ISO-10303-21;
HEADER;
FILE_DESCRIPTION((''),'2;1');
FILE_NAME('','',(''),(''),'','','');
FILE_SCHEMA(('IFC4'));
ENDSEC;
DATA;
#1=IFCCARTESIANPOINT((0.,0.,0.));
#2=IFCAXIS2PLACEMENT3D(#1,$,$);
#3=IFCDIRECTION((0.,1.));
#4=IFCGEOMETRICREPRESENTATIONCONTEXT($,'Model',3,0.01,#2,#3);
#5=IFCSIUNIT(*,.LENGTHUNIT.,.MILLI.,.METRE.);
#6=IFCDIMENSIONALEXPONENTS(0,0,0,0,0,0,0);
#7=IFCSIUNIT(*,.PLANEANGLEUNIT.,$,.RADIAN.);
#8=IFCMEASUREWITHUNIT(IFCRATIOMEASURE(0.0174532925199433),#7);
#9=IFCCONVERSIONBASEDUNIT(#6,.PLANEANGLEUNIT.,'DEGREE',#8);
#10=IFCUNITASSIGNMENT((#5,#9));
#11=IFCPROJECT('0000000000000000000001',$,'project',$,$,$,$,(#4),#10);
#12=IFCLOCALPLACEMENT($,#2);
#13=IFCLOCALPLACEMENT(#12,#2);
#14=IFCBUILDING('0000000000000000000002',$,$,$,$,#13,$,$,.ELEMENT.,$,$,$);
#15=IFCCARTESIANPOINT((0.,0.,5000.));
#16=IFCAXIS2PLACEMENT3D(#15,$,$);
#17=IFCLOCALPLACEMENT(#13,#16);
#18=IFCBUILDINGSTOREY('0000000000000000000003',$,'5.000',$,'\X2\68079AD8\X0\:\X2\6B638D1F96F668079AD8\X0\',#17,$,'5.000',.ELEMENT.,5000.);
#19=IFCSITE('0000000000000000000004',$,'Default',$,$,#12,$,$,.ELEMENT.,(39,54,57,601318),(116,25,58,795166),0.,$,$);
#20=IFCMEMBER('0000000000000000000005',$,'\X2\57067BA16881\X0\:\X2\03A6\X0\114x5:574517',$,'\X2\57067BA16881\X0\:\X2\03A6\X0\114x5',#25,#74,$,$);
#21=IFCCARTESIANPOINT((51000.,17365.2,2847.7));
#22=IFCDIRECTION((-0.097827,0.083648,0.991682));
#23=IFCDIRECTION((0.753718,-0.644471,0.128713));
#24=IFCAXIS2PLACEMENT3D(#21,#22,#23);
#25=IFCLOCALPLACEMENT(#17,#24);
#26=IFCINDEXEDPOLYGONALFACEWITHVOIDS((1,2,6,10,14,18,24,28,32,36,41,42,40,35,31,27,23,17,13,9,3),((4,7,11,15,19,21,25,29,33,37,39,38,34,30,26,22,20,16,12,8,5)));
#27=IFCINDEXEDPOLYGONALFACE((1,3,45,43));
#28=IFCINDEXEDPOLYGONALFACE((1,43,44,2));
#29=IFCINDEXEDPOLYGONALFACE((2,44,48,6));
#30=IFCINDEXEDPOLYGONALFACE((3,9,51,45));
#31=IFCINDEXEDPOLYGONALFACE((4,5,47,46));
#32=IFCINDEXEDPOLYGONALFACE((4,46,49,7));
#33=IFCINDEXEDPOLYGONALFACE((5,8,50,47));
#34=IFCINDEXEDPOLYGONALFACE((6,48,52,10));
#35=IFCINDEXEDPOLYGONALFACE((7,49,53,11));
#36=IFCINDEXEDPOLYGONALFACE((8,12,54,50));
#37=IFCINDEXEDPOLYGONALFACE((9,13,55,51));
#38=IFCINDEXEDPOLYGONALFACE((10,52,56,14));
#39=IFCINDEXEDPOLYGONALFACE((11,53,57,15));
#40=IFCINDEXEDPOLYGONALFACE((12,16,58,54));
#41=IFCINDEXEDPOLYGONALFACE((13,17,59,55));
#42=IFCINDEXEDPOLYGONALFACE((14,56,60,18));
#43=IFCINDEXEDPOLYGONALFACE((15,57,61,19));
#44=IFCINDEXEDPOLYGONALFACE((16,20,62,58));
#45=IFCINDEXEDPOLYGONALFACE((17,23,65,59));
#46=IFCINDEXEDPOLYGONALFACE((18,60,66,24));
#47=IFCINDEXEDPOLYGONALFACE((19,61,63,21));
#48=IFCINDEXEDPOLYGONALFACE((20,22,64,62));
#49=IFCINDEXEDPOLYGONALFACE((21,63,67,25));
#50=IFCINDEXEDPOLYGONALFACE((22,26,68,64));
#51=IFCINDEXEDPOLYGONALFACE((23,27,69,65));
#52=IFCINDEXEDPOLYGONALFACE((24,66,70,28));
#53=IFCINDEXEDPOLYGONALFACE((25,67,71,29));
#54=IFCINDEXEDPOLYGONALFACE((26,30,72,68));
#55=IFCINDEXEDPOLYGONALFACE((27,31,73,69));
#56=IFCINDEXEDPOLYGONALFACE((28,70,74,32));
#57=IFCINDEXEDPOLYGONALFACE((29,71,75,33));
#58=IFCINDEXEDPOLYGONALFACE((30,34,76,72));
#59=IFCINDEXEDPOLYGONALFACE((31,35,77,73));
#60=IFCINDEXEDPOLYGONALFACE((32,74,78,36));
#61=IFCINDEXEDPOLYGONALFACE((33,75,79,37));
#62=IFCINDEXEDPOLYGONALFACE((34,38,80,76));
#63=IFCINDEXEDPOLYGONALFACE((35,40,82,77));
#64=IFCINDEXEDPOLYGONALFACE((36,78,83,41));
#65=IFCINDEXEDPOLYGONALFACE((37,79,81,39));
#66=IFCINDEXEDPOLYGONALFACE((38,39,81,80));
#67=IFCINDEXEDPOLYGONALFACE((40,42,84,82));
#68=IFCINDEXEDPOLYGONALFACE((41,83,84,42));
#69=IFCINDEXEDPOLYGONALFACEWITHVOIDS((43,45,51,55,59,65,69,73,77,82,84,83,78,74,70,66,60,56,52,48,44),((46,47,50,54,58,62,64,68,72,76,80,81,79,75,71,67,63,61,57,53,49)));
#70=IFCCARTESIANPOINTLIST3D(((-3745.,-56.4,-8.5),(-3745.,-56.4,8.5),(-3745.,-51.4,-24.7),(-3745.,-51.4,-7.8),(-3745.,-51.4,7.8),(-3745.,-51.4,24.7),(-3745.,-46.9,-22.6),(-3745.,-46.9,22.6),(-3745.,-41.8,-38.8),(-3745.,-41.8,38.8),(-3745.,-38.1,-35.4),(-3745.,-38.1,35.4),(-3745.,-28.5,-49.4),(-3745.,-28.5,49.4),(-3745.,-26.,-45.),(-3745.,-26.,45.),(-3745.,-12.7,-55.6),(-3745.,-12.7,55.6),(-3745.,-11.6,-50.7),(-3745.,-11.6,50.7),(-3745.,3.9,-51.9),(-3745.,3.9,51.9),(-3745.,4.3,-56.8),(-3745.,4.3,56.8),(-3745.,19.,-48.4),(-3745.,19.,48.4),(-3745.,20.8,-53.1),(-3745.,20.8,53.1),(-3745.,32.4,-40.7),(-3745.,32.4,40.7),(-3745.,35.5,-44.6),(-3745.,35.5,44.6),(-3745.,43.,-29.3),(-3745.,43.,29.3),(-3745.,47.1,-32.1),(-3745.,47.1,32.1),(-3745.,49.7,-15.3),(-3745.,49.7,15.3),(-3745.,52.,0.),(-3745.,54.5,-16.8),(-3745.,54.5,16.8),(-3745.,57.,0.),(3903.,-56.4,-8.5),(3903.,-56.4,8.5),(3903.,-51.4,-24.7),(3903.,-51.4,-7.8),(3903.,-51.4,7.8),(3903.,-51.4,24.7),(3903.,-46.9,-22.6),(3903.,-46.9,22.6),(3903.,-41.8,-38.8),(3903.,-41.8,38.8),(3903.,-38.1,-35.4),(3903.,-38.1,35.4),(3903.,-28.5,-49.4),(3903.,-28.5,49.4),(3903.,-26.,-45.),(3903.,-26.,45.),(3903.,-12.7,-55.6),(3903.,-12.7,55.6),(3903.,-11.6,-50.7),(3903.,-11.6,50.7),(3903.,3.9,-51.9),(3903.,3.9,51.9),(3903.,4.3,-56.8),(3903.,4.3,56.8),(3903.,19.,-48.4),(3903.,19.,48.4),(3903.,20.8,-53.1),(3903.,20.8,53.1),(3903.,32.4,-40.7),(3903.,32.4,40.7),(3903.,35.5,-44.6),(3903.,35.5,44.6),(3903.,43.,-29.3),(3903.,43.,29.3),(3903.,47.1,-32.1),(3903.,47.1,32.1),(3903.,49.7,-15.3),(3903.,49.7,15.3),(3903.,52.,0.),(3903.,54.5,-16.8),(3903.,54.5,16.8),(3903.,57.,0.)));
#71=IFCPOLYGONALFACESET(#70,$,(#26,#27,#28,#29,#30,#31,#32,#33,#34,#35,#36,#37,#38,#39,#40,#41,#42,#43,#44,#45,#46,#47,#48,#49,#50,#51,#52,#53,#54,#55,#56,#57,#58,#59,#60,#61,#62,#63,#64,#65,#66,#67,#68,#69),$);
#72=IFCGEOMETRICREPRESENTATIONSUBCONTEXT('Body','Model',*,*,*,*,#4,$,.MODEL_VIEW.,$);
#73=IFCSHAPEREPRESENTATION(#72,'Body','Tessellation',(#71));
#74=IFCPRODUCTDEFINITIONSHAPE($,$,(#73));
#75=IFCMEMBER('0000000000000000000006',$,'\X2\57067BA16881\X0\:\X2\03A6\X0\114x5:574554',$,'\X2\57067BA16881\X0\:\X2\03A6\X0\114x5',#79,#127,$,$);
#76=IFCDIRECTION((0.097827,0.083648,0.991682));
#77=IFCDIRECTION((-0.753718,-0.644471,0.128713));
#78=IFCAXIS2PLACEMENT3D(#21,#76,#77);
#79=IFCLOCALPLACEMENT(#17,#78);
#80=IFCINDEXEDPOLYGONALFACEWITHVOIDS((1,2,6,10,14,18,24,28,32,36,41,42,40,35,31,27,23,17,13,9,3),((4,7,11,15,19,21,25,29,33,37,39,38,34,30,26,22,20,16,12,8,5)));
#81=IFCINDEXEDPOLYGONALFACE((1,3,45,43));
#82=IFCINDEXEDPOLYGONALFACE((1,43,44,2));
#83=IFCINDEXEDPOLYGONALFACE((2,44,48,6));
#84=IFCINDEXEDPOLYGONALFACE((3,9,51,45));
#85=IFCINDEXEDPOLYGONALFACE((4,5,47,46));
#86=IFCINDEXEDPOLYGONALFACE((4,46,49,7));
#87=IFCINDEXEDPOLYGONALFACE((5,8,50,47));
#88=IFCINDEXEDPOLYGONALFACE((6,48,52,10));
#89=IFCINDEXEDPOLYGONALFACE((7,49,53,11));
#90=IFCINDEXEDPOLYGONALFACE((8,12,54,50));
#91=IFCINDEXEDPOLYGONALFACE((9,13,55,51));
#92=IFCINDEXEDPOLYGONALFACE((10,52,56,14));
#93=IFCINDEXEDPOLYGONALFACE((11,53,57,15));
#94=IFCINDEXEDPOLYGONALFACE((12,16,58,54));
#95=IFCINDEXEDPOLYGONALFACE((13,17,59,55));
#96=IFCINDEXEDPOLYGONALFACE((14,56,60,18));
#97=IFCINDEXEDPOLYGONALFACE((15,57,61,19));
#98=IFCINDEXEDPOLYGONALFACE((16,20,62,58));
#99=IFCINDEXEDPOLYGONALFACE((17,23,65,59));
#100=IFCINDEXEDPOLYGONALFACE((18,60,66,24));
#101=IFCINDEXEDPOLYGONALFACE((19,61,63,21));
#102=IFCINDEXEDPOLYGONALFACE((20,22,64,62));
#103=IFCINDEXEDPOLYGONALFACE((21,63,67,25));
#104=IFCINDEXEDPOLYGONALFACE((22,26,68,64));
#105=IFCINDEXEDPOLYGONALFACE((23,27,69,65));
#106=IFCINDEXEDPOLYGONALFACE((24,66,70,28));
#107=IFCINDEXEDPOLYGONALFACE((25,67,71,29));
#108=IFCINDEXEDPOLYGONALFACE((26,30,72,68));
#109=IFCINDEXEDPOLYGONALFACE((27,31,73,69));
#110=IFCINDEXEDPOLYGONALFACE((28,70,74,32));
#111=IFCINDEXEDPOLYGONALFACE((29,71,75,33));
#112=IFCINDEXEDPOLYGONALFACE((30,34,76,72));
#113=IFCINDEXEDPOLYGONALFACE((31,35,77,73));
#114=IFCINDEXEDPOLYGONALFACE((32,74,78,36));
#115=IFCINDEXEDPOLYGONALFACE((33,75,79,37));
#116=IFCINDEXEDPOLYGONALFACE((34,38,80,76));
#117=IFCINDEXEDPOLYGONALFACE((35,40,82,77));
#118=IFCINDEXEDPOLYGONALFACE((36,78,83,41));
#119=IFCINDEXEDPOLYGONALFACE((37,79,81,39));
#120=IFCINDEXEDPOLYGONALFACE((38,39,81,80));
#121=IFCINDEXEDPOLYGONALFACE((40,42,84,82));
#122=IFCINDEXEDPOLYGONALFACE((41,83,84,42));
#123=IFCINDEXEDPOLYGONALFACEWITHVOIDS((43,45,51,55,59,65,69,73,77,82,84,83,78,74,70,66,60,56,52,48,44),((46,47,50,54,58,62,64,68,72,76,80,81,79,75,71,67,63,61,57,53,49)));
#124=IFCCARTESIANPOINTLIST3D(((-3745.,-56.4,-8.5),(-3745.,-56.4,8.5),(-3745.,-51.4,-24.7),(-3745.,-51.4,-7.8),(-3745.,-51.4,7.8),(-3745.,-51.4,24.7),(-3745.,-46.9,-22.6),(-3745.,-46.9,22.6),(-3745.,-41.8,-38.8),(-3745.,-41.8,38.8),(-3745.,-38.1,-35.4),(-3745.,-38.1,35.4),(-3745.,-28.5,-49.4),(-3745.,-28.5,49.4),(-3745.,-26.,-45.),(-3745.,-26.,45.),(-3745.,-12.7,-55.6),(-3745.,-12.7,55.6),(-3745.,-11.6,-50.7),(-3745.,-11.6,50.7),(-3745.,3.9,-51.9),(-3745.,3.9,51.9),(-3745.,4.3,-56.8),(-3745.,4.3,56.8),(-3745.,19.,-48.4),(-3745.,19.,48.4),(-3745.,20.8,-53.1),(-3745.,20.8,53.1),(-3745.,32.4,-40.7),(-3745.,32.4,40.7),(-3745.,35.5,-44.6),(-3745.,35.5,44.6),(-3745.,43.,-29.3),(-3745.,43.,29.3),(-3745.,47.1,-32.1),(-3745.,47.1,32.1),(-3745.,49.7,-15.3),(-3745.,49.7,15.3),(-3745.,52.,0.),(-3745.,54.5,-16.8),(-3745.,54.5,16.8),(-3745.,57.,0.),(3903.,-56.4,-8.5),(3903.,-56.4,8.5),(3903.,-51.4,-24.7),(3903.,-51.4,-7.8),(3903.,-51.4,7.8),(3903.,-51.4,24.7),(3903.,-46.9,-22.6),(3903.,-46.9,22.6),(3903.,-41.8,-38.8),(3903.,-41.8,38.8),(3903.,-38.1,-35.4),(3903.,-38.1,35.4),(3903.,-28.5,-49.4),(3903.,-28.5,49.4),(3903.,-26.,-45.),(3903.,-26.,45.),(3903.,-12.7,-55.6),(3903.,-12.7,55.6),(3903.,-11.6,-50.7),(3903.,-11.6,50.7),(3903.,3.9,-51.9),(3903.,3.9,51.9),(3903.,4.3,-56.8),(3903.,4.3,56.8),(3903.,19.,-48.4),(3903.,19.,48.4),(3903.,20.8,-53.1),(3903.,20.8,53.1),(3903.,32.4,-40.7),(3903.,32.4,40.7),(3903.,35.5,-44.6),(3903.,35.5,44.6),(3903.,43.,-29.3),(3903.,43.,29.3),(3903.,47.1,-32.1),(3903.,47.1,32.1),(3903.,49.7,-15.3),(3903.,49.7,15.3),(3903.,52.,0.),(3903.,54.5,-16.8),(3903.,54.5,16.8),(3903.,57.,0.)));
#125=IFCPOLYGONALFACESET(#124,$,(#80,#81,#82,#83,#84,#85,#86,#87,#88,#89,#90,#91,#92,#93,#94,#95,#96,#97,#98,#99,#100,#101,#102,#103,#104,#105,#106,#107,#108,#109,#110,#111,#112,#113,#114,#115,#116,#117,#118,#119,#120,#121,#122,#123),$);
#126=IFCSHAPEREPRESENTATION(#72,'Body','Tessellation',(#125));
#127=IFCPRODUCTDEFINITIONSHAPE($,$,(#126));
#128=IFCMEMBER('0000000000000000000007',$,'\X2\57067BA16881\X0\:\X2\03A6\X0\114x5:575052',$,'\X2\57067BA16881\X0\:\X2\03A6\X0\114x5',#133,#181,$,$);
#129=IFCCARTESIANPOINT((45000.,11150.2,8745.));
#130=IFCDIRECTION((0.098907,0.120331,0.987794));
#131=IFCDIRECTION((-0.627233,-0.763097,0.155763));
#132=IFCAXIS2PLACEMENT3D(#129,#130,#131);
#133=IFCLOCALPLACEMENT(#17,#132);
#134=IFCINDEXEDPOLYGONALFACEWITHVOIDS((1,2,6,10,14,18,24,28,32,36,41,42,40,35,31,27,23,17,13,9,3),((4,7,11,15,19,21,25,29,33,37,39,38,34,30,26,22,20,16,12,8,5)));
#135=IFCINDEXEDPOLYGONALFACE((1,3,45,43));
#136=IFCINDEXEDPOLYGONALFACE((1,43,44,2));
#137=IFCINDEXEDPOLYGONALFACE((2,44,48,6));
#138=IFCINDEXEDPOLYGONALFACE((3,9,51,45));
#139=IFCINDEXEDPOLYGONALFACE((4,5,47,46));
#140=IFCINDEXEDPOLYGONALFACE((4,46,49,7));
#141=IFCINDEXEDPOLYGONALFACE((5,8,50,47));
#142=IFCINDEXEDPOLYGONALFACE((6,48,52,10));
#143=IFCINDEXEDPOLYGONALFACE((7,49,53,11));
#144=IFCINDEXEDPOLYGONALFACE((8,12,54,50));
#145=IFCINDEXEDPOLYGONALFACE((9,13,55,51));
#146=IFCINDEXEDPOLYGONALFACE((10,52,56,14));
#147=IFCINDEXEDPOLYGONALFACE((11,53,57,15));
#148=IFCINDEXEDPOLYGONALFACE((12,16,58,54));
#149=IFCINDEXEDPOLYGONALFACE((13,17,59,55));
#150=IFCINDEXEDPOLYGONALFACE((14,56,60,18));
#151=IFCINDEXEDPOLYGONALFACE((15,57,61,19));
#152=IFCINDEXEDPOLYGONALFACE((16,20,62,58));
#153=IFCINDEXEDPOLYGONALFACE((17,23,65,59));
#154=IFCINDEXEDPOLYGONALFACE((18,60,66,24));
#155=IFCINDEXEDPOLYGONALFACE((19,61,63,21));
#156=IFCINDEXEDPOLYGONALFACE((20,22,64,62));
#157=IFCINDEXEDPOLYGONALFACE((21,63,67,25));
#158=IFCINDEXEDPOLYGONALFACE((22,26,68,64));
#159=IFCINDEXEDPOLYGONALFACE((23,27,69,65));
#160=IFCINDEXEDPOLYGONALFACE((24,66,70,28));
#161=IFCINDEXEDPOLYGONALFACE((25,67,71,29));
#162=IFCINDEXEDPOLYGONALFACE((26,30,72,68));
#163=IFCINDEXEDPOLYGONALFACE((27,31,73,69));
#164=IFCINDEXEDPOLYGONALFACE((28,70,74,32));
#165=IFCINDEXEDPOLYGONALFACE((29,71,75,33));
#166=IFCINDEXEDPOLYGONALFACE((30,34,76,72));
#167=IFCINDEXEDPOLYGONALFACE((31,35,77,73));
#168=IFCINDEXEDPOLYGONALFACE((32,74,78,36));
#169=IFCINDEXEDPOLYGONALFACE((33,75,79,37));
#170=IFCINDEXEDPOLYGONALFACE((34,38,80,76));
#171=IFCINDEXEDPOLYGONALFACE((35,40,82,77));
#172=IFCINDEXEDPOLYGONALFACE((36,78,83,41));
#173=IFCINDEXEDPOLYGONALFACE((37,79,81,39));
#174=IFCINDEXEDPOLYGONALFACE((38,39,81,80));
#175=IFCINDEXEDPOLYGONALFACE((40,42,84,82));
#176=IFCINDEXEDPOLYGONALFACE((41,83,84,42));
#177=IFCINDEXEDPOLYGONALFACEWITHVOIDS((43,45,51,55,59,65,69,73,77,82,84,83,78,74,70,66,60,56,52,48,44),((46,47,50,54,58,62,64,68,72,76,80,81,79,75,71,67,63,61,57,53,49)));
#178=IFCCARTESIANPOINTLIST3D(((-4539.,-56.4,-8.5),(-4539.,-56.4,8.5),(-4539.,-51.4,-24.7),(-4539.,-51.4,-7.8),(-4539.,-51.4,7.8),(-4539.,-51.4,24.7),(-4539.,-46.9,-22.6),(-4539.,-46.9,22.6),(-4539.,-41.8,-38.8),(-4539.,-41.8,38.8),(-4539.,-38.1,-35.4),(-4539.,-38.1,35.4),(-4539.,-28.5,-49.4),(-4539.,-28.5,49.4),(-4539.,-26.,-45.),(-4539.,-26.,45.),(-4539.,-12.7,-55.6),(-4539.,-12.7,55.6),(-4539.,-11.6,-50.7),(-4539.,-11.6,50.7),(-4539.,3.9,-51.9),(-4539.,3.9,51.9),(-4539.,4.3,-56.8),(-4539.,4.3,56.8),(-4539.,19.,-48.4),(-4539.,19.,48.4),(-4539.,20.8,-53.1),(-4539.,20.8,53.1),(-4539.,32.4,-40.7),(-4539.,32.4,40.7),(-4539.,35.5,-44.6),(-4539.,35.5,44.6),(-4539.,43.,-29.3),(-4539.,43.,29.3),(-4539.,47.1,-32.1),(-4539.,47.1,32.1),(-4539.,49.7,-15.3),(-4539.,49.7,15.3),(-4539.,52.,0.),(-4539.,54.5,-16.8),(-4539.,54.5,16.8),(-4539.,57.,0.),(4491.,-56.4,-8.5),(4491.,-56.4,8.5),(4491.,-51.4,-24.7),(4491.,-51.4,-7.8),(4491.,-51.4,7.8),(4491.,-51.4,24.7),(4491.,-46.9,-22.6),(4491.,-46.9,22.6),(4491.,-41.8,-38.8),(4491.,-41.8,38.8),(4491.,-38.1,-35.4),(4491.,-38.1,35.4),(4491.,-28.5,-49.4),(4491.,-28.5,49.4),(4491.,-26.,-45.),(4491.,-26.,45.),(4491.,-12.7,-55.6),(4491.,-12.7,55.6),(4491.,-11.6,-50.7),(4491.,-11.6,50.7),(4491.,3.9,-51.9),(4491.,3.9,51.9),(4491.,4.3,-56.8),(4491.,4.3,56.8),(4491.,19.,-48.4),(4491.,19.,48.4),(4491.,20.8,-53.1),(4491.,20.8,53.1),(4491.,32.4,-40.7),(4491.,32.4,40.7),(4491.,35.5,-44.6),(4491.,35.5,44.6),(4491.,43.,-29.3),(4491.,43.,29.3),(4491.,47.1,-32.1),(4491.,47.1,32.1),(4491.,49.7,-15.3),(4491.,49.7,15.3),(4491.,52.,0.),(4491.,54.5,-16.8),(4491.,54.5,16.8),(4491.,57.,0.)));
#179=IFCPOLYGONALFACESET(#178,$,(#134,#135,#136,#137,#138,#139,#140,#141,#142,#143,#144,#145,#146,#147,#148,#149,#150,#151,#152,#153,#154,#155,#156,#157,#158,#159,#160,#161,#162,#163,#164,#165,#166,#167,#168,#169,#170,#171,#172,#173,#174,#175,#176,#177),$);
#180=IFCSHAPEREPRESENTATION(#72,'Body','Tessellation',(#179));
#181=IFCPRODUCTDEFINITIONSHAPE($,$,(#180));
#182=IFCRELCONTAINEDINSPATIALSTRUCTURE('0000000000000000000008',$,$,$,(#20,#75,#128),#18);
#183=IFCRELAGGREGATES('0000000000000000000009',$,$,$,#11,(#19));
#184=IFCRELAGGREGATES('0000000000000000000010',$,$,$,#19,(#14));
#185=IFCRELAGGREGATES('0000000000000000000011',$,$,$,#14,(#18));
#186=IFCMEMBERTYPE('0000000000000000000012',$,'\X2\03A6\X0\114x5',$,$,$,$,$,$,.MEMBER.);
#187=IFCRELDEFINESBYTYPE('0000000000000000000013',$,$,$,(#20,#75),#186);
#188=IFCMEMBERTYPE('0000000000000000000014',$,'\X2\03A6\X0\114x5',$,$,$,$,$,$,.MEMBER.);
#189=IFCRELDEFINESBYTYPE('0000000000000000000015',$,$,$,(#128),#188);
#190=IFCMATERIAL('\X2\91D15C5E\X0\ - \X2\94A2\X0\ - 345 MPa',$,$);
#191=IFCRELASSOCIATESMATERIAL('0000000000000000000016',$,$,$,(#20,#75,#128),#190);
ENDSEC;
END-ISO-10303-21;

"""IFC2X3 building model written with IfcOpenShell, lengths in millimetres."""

from ifc_helpers import new_model, entity, si_unit, converted_unit, direction, frame, frame_2d, origin, place, context, subcontext, project, spatial, hollow_circle, extrude, source, transform, mapped, material, type_object, type_shapes, element, save


model = new_model("IFC2X3")

# Units and contexts
model_context = context("Model", 3, precision=0.01, world=origin(), true_north=direction((0.0, 1.0)))
body_context = subcontext(model_context, "Body", "Model", "MODEL_VIEW")
ifc_project = project(units=[si_unit("LENGTHUNIT", "METRE", prefix="MILLI"), converted_unit("PLANEANGLEUNIT", "DEGREE", entity("IfcRatioMeasure", 0.0174532925199433), si_unit("PLANEANGLEUNIT", "RADIAN"), dimensions=[0, 0, 0, 0, 0, 0, 0])], contexts=[model_context])

# Site, building, storey
site_placement = place(None, origin())
site = spatial("IfcSite", under=ifc_project, at=site_placement, Name="Default", CompositionType="ELEMENT", RefLatitude=(39, 54, 57, 601318), RefLongitude=(116, 25, 58, 795166), RefElevation=0.0)
building_placement = place(site_placement, origin())
building = spatial("IfcBuilding", under=site, at=building_placement, CompositionType="ELEMENT")
storey_placement = place(building_placement, frame((0.0, 0.0, 5000.0)))
storey = spatial("IfcBuildingStorey", under=building, at=storey_placement, Name="5.000", ObjectType="标高:正负零标高", LongName="5.000", CompositionType="ELEMENT", Elevation=5000.0)

# Members
ifc_material_1 = material(Name="金属 - 钢 - 345 MPa")
member_type_1 = type_object("IfcMemberType", Name="Φ114x5", PredefinedType="MEMBER")
shared_shape_1 = source(origin(), body_context, "Body", "SweptSolid", [
    extrude(hollow_circle(Radius=57.0, WallThickness=5.0, at=frame_2d((0.0, 0.0), x_axis=(1.0, 0.0))), frame((-3745.0, 0.0, 0.0), z_axis=(1.0, 0.0, 0.0), x_axis=(0.0, 1.0, 0.0)), (0.0, 0.0, 1.0), 7648.0),
])
type_shapes(member_type_1, [shared_shape_1])
for number, where, z_axis, x_axis, name in (
    (1, (51000.0, 17365.2, 2847.7), (-0.097827, 0.083648, 0.991682), (0.753718, -0.644471, 0.128713), "圆管梁:Φ114x5:574517"),
    (2, (51000.0, 17365.2, 2847.7), (0.097827, 0.083648, 0.991682), (-0.753718, -0.644471, 0.128713), "圆管梁:Φ114x5:574554"),
):
    element("IfcMember", number, at=place(storey_placement, frame(where, z_axis=z_axis, x_axis=x_axis)), inside=storey, type_object=member_type_1, material=ifc_material_1, Name=name, ObjectType="圆管梁:Φ114x5", context=body_context, shape_type="MappedRepresentation", body=[
        mapped(shared_shape_1, transform((0.0, 0.0, 0.0), scale=1.0)),
    ])
member_type_2 = type_object("IfcMemberType", Name="Φ114x5", PredefinedType="MEMBER")
shared_shape_2 = source(origin(), body_context, "Body", "SweptSolid", [
    extrude(hollow_circle(Radius=57.0, WallThickness=5.0, at=frame_2d((0.0, 0.0), x_axis=(1.0, 0.0))), frame((-4539.0, 0.0, 0.0), z_axis=(1.0, 0.0, 0.0), x_axis=(0.0, 1.0, 0.0)), (0.0, 0.0, 1.0), 9030.0),
])
type_shapes(member_type_2, [shared_shape_2])
for number, where, z_axis, x_axis, name in (
    (3, (45000.0, 11150.2, 8745.0), (0.098907, 0.120331, 0.987794), (-0.627233, -0.763097, 0.155763), "圆管梁:Φ114x5:575052"),
):
    element("IfcMember", number, at=place(storey_placement, frame(where, z_axis=z_axis, x_axis=x_axis)), inside=storey, type_object=member_type_2, material=ifc_material_1, Name=name, ObjectType="圆管梁:Φ114x5", context=body_context, shape_type="MappedRepresentation", body=[
        mapped(shared_shape_2, transform((0.0, 0.0, 0.0), scale=1.0)),
    ])

save(model, "model.ifc")
